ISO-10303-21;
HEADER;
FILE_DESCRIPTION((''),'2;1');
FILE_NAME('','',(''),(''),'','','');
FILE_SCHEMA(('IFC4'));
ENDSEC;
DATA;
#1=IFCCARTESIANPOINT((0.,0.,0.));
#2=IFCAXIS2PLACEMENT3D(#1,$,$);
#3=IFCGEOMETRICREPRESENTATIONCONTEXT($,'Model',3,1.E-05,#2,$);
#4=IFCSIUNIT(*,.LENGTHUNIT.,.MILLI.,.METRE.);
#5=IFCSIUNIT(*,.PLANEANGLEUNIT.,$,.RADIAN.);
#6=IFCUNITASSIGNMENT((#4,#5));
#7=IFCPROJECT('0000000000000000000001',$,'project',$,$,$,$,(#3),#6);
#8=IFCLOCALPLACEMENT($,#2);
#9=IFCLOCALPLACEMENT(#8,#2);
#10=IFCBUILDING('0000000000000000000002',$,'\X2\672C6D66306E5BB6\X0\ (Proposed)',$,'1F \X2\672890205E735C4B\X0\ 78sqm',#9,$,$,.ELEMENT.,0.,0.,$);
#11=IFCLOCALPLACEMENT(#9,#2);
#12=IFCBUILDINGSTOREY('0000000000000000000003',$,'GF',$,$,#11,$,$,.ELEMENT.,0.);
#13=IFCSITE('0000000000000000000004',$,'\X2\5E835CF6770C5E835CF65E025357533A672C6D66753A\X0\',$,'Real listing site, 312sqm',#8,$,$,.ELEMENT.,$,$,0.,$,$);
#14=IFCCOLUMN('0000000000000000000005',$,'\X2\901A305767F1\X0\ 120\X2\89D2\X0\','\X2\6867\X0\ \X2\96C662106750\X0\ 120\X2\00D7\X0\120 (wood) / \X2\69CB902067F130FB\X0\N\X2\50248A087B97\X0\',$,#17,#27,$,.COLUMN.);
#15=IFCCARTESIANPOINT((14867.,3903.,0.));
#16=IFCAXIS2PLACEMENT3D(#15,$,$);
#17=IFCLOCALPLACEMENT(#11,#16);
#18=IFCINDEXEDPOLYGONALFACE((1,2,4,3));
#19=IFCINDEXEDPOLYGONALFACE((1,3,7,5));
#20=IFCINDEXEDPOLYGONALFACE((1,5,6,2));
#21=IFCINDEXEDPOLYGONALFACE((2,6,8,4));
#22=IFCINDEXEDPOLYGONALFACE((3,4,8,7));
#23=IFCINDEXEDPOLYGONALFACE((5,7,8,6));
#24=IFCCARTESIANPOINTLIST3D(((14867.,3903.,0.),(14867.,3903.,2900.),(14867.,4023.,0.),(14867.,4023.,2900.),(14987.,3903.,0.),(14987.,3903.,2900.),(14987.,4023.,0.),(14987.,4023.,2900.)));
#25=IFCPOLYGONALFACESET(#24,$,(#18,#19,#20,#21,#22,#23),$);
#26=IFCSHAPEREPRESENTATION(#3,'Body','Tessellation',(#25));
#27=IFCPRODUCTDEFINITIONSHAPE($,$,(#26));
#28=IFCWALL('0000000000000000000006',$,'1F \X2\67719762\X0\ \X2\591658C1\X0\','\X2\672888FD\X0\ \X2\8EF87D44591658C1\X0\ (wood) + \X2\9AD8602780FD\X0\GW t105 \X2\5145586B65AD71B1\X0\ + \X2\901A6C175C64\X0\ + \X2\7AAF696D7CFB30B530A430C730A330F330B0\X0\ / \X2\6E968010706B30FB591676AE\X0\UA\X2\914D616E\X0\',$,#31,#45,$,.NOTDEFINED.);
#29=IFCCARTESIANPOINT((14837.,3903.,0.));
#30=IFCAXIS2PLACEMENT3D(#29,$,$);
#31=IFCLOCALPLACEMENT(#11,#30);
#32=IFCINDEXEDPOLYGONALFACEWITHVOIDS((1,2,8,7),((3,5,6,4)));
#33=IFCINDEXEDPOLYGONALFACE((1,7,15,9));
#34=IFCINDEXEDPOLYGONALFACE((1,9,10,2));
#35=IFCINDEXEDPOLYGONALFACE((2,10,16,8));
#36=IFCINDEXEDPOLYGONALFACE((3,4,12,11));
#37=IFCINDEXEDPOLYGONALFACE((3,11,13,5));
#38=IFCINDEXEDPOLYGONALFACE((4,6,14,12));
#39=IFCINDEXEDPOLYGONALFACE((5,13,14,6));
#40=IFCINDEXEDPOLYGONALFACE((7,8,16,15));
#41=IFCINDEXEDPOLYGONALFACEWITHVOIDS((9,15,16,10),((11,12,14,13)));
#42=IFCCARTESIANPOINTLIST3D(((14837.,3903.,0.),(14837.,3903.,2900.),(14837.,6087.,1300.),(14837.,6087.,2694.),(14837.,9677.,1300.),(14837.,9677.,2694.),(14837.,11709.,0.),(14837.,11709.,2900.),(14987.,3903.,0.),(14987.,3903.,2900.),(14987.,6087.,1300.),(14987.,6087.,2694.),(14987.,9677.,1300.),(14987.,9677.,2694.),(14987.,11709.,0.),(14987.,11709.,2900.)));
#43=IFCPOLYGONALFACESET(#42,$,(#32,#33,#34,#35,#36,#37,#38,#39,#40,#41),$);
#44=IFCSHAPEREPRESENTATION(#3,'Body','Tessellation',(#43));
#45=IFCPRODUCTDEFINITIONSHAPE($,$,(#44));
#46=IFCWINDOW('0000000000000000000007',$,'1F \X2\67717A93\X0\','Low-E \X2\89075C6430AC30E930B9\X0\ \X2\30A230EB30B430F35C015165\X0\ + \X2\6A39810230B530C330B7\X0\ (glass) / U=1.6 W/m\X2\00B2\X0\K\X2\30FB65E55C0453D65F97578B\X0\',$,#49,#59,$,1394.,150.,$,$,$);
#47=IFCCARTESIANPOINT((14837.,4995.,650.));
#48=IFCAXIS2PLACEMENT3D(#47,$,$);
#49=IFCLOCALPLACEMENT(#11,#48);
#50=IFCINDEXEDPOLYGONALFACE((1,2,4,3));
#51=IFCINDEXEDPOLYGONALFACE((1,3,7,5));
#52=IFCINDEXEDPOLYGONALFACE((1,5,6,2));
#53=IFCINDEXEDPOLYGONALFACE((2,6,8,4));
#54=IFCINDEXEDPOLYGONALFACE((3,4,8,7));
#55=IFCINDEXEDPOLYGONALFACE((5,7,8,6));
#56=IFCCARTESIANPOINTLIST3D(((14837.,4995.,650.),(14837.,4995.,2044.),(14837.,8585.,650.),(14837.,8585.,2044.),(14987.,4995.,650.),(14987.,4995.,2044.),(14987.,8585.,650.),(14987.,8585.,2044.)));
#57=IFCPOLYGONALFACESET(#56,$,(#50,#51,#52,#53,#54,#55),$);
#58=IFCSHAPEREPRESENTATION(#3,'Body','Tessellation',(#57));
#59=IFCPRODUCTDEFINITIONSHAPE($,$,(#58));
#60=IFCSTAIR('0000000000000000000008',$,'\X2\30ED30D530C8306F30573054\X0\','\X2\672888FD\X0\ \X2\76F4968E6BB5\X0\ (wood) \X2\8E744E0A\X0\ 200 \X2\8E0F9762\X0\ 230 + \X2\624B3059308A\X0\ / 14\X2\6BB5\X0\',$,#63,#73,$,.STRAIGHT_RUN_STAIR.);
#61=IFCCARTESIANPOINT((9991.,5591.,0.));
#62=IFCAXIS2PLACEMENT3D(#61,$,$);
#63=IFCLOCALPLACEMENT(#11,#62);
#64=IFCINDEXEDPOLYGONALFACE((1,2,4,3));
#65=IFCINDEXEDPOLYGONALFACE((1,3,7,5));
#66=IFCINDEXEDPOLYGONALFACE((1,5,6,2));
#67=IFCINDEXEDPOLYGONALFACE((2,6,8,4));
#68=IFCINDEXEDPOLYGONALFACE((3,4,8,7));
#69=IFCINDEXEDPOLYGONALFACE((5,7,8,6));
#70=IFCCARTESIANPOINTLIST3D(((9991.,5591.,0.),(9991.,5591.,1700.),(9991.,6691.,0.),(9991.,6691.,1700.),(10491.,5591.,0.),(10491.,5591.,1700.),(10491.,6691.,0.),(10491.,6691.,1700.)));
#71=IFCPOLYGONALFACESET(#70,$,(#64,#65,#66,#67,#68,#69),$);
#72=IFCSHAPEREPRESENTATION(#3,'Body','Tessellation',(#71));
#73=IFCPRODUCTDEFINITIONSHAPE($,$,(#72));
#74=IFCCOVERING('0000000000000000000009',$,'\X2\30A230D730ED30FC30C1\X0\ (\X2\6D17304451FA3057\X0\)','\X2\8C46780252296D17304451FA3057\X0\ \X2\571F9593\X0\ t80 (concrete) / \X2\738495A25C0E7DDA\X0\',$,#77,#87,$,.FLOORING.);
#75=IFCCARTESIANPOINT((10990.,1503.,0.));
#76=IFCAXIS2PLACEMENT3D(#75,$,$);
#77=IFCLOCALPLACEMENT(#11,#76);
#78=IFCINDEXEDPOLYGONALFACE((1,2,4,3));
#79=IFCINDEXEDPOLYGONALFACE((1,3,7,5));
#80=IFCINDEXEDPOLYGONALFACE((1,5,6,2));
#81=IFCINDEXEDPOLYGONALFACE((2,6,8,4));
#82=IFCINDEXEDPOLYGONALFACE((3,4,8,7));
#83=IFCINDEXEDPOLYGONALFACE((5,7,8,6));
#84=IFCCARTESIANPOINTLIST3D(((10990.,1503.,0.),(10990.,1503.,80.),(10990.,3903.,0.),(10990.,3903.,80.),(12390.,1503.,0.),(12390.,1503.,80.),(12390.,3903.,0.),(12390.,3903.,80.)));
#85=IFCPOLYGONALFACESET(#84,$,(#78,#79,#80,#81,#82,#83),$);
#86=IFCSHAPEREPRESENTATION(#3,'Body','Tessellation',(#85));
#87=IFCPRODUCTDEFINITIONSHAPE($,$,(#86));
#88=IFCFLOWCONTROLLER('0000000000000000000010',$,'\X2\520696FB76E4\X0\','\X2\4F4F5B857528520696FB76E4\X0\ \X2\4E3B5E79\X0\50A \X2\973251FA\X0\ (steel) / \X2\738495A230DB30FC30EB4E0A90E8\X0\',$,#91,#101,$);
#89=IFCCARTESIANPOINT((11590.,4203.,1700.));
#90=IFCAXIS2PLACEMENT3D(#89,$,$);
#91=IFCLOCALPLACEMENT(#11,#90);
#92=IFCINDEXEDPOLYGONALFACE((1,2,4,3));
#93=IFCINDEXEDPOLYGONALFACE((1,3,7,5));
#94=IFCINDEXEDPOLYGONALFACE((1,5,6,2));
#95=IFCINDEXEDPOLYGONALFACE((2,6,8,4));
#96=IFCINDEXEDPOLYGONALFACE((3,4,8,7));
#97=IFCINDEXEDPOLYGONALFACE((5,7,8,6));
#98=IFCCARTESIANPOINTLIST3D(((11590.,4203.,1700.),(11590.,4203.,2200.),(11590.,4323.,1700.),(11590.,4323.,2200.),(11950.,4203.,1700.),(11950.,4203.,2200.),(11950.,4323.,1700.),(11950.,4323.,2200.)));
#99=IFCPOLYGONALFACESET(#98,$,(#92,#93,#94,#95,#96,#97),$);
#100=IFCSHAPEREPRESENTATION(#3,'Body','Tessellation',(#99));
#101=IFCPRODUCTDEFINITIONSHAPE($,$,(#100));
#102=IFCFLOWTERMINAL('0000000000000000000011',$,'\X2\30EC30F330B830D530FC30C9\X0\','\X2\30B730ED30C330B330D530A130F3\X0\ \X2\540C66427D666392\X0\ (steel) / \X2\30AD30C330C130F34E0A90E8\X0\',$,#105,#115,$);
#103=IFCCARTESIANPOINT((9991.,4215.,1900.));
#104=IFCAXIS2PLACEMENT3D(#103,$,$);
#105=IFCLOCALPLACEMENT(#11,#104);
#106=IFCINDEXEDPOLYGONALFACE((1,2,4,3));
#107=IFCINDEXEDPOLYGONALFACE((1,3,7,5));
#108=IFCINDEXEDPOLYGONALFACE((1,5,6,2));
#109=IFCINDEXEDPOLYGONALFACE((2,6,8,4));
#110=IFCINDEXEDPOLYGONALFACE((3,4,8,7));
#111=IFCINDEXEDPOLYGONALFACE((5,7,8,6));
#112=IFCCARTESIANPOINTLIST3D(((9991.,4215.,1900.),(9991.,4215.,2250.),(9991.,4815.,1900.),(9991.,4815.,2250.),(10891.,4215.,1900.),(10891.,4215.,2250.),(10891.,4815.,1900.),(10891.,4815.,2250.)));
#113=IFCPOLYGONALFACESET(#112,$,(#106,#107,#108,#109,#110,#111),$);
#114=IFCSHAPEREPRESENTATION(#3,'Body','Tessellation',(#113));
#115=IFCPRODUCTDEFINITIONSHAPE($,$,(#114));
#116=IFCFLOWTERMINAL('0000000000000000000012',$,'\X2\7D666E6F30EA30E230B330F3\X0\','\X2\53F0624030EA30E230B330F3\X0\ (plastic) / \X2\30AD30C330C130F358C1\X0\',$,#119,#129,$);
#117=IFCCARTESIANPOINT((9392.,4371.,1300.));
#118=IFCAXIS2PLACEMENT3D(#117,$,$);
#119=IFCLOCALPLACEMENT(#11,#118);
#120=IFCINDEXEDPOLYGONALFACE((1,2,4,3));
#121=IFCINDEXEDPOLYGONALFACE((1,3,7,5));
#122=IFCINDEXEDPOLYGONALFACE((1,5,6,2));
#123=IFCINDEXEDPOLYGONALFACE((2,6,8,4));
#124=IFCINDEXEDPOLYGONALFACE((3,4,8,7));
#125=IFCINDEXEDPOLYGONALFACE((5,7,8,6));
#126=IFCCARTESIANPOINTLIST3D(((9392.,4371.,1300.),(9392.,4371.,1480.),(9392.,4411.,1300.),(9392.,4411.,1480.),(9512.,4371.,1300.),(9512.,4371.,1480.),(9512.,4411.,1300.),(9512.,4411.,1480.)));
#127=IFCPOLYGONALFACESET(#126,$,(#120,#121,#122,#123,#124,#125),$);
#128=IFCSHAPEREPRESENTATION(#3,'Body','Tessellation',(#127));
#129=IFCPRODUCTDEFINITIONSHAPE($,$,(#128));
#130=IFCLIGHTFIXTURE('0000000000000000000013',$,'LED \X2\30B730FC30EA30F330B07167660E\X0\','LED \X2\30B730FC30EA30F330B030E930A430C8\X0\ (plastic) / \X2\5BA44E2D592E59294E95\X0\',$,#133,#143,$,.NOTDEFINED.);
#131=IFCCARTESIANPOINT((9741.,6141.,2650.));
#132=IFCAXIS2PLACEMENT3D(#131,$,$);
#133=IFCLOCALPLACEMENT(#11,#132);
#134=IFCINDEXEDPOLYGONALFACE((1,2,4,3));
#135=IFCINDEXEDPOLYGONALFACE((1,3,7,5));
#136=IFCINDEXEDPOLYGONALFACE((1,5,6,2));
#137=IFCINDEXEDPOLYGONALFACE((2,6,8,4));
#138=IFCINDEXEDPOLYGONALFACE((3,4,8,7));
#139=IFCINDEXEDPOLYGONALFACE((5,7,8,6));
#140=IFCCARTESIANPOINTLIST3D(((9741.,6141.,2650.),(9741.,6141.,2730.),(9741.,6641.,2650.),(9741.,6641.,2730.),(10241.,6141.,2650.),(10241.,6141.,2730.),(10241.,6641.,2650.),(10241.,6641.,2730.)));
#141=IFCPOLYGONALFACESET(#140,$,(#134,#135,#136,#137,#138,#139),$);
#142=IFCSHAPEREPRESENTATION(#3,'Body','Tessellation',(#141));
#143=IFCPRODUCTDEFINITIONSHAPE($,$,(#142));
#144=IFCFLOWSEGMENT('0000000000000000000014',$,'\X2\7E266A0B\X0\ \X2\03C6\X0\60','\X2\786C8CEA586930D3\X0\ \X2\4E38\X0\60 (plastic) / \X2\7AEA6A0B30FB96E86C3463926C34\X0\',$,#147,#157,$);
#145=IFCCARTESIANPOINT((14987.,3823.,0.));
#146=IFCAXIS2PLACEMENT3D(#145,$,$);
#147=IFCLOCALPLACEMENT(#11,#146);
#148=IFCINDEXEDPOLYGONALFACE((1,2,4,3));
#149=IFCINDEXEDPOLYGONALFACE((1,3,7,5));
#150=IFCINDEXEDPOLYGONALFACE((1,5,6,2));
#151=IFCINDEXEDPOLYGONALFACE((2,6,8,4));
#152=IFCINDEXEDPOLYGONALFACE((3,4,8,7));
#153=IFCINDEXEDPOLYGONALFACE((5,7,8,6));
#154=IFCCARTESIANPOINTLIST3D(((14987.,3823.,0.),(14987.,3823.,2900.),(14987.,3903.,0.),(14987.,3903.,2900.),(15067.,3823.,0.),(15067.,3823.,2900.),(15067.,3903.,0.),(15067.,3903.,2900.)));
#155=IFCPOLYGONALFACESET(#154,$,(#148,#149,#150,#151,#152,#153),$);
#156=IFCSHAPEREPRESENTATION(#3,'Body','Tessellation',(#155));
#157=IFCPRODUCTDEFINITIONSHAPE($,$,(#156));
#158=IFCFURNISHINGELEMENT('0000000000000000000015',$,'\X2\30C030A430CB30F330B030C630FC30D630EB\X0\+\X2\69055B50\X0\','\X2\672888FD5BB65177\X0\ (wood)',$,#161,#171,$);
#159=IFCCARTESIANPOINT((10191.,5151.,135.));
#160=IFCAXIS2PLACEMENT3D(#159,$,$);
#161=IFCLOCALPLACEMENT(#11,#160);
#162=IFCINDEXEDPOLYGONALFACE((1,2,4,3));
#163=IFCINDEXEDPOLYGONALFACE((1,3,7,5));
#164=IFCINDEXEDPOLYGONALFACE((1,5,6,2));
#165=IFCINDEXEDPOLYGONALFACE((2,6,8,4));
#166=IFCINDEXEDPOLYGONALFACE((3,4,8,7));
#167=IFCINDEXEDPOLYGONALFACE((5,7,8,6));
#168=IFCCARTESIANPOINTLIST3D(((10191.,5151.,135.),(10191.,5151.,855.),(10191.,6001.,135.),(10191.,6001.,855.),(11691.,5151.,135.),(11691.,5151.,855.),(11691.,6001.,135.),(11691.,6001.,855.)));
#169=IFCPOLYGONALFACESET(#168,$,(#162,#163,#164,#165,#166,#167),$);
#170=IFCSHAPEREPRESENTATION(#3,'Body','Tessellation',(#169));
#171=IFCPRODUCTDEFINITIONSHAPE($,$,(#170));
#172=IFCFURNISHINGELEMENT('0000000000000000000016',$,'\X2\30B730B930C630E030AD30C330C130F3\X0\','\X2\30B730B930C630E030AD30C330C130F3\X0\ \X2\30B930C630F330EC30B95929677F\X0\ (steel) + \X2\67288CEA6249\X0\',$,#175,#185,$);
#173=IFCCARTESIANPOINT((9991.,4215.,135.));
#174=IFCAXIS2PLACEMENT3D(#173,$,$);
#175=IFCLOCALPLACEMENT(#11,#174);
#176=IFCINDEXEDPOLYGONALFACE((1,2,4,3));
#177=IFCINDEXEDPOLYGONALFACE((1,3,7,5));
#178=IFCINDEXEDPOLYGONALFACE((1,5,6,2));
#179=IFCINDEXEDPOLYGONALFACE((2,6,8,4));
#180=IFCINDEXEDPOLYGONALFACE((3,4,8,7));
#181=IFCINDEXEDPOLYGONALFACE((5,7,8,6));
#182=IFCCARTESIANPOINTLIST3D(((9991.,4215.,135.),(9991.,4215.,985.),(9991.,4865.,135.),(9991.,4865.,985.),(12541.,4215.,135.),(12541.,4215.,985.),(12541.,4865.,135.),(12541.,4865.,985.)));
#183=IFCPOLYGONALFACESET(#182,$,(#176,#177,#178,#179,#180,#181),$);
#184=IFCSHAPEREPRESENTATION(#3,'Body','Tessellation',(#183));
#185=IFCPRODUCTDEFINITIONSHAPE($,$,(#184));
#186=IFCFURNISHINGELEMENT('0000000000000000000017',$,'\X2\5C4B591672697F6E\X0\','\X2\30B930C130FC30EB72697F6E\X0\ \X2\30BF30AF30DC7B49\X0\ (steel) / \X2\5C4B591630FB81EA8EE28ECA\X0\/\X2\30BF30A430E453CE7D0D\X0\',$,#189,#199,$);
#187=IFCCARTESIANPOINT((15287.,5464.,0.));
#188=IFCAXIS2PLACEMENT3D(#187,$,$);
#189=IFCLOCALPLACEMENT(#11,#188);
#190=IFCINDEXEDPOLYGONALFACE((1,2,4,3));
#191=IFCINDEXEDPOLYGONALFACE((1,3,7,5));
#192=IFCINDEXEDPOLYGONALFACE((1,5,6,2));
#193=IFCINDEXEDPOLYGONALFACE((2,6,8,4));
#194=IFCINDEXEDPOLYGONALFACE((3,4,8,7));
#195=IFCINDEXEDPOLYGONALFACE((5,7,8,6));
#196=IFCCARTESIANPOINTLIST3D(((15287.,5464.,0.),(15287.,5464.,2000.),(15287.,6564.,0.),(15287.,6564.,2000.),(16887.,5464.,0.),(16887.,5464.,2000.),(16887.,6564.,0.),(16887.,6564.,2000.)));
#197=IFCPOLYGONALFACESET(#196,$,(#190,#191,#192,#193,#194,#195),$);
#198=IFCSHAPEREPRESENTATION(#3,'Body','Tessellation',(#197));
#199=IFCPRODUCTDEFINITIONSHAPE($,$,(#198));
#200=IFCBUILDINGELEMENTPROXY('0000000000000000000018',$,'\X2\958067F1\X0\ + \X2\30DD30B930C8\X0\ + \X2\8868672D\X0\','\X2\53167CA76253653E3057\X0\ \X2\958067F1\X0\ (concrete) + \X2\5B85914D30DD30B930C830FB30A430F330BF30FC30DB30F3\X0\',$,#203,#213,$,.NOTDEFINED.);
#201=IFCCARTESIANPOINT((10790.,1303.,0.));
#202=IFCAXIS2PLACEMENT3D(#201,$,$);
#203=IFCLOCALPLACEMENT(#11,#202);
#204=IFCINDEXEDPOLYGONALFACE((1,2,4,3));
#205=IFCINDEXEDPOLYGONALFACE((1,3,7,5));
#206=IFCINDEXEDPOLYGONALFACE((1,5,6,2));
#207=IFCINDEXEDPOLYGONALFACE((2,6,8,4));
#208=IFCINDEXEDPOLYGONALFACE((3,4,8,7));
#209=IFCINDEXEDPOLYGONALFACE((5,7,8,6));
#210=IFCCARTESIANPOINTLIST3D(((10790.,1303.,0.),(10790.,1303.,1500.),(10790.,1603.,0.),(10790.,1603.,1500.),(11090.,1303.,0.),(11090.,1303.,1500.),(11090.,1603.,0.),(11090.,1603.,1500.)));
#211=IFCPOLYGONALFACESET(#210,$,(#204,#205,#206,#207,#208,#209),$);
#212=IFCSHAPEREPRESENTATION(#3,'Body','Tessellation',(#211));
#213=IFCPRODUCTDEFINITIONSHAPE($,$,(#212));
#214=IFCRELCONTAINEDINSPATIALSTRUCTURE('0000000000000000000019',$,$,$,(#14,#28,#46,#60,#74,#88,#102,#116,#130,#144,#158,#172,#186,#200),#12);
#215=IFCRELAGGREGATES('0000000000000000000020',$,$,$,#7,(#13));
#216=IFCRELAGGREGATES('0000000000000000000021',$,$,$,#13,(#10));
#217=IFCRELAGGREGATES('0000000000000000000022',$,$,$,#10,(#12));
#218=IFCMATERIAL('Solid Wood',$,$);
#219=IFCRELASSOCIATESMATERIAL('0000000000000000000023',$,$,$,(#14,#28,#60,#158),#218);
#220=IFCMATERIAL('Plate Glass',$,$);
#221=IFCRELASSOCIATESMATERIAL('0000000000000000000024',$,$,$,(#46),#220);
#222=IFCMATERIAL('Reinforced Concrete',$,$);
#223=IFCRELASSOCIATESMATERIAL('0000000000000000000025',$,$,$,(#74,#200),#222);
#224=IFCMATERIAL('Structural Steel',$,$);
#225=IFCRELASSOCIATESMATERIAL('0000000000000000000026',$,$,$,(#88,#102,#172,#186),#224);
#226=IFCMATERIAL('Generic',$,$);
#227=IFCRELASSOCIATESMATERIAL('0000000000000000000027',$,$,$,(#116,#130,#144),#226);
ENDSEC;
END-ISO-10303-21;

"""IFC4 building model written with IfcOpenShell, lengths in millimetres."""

from ifc_helpers import new_model, si_unit, frame, frame_2d, origin, place, context, project, spatial, rectangle, extrude, material, element, fill, save


model = new_model("IFC4")

# Units and contexts
model_context = context("Model", 3, precision=1e-05, world=origin())
ifc_project = project(units=[si_unit("LENGTHUNIT", "METRE", prefix="MILLI"), si_unit("PLANEANGLEUNIT", "RADIAN")], contexts=[model_context])

# Site, building, storey
site_placement = place(None, origin())
site = spatial("IfcSite", under=ifc_project, at=site_placement, Name="広島県広島市南区本浦町", ObjectType="Real listing site, 312sqm", CompositionType="ELEMENT", RefElevation=0.0)
building_placement = place(site_placement, origin())
building = spatial("IfcBuilding", under=site, at=building_placement, Name="本浦の家 (Proposed)", ObjectType="1F 木造平屋 78sqm", CompositionType="ELEMENT", ElevationOfRefHeight=0.0, ElevationOfTerrain=0.0)
storey_placement = place(building_placement, origin())
storey = spatial("IfcBuildingStorey", under=building, at=storey_placement, Name="GF", CompositionType="ELEMENT", Elevation=0.0)

# Column
ifc_material_1 = material(Name="Solid Wood")
column_1_placement = place(storey_placement, frame((14867.0, 3903.0, 0.0)))
element("IfcColumn", 1, at=column_1_placement, inside=storey, material=ifc_material_1, Name="通し柱 120角", Description="桧 集成材 120×120 (wood) / 構造柱・N値計算", PredefinedType="COLUMN", context=model_context, shape_type="SweptSolid", body=[
    extrude(rectangle(XDim=120.0, YDim=120.0, at=frame_2d((60.0, 60.0))), frame((14867.0, 3903.0, 0.0)), (0.0, 0.0, 1.0), 2900.0),
])

# Wall, opening, window
wall_1_placement = place(storey_placement, frame((14837.0, 3903.0, 0.0)))
wall_1 = element("IfcWall", 2, at=wall_1_placement, inside=storey, material=ifc_material_1, Name="1F 東面 外壁", Description="木製 軸組外壁 (wood) + 高性能GW t105 充填断熱 + 通気層 + 窯業系サイディング / 準耐火・外皮UA配慮", PredefinedType="NOTDEFINED", context=model_context, shape_type="SweptSolid", body=[
    extrude(rectangle(XDim=150.0, YDim=7806.0, at=frame_2d((75.0, 3903.0))), frame((14837.0, 3903.0, 0.0)), (0.0, 0.0, 1.0), 2900.0),
])
opening_placement = place(storey_placement, frame((14837.0, 4995.0, 650.0)))
opening = element("IfcOpeningElement", 3, at=opening_placement, cuts=wall_1, PredefinedType="NOTDEFINED", context=model_context, shape_type="SweptSolid", body=[
    extrude(rectangle(XDim=150.0, YDim=3590.0, at=frame_2d((75.0, 1795.0))), frame((14837.0, 4995.0, 650.0)), (0.0, 0.0, 1.0), 1394.0),
])
ifc_material_2 = material(Name="Plate Glass")
window_placement = place(storey_placement, frame((14837.0, 4995.0, 650.0)))
window = element("IfcWindow", 4, at=window_placement, inside=storey, material=ifc_material_2, Name="1F 東窓", Description="Low-E 複層ガラス アルゴン封入 + 樹脂サッシ (glass) / U=1.6 W/m²K・日射取得型", OverallHeight=1394.0, OverallWidth=150.0, context=model_context, shape_type="SweptSolid", body=[
    extrude(rectangle(XDim=150.0, YDim=3590.0, at=frame_2d((75.0, 1795.0))), frame((14837.0, 4995.0, 650.0)), (0.0, 0.0, 1.0), 1394.0),
])
fill(opening, window)

# Stair
stair_placement = place(storey_placement, frame((9991.0, 5591.0, 0.0)))
element("IfcStair", 5, at=stair_placement, inside=storey, material=ifc_material_1, Name="ロフトはしご", Description="木製 直階段 (wood) 蹴上 200 踏面 230 + 手すり / 14段", PredefinedType="STRAIGHT_RUN_STAIR", context=model_context, shape_type="SweptSolid", body=[
    extrude(rectangle(XDim=500.0, YDim=1100.0, at=frame_2d((250.0, 550.0))), frame((9991.0, 5591.0, 0.0)), (0.0, 0.0, 1.0), 1700.0),
])

# Covering
ifc_material_3 = material(Name="Reinforced Concrete")
covering_placement = place(storey_placement, frame((10990.0, 1503.0, 0.0)))
element("IfcCovering", 6, at=covering_placement, inside=storey, material=ifc_material_3, Name="アプローチ (洗い出し)", Description="豆砂利洗い出し 土間 t80 (concrete) / 玄関導線", PredefinedType="FLOORING", context=model_context, shape_type="SweptSolid", body=[
    extrude(rectangle(XDim=1400.0, YDim=2400.0, at=frame_2d((700.0, 1200.0))), frame((10990.0, 1503.0, 0.0)), (0.0, 0.0, 1.0), 80.0),
])

# Flow controller
ifc_material_4 = material(Name="Structural Steel")
flow_controller_placement = place(storey_placement, frame((11590.0, 4203.0, 1700.0)))
element("IfcFlowController", 7, at=flow_controller_placement, inside=storey, material=ifc_material_4, Name="分電盤", Description="住宅用分電盤 主幹50A 露出 (steel) / 玄関ホール上部", context=model_context, shape_type="SweptSolid", body=[
    extrude(rectangle(XDim=360.0, YDim=120.0, at=frame_2d((180.0, 60.0))), frame((11590.0, 4203.0, 1700.0)), (0.0, 0.0, 1.0), 500.0),
])

# Flow terminals
flow_terminal_1_placement = place(storey_placement, frame((9991.0, 4215.0, 1900.0)))
element("IfcFlowTerminal", 8, at=flow_terminal_1_placement, inside=storey, material=ifc_material_4, Name="レンジフード", Description="シロッコファン 同時給排 (steel) / キッチン上部", context=model_context, shape_type="SweptSolid", body=[
    extrude(rectangle(XDim=900.0, YDim=600.0, at=frame_2d((450.0, 300.0))), frame((9991.0, 4215.0, 1900.0)), (0.0, 0.0, 1.0), 350.0),
])
ifc_material_5 = material(Name="Generic")
flow_terminal_2_placement = place(storey_placement, frame((9392.0, 4371.0, 1300.0)))
element("IfcFlowTerminal", 9, at=flow_terminal_2_placement, inside=storey, material=ifc_material_5, Name="給湯リモコン", Description="台所リモコン (plastic) / キッチン壁", context=model_context, shape_type="SweptSolid", body=[
    extrude(rectangle(XDim=120.0, YDim=40.0, at=frame_2d((60.0, 20.0))), frame((9392.0, 4371.0, 1300.0)), (0.0, 0.0, 1.0), 180.0),
])

# Light fixture
light_fixture_placement = place(storey_placement, frame((9741.0, 6141.0, 2650.0)))
element("IfcLightFixture", 10, at=light_fixture_placement, inside=storey, material=ifc_material_5, Name="LED シーリング照明", Description="LED シーリングライト (plastic) / 室中央天井", PredefinedType="NOTDEFINED", context=model_context, shape_type="SweptSolid", body=[
    extrude(rectangle(XDim=500.0, YDim=500.0, at=frame_2d((250.0, 250.0))), frame((9741.0, 6141.0, 2650.0)), (0.0, 0.0, 1.0), 80.0),
])

# Flow segment
flow_segment_placement = place(storey_placement, frame((14987.0, 3823.0, 0.0)))
element("IfcFlowSegment", 11, at=flow_segment_placement, inside=storey, material=ifc_material_5, Name="縦樋 φ60", Description="硬質塩ビ 丸60 (plastic) / 竪樋・雨水排水", context=model_context, shape_type="SweptSolid", body=[
    extrude(rectangle(XDim=80.0, YDim=80.0, at=frame_2d((40.0, 40.0))), frame((14987.0, 3823.0, 0.0)), (0.0, 0.0, 1.0), 2900.0),
])

# Furnishing elements
furnishing_1_placement = place(storey_placement, frame((10191.0, 5151.0, 135.0)))
element("IfcFurnishingElement", 12, at=furnishing_1_placement, inside=storey, material=ifc_material_1, Name="ダイニングテーブル+椅子", Description="木製家具 (wood)", context=model_context, shape_type="SweptSolid", body=[
    extrude(rectangle(XDim=1500.0, YDim=850.0, at=frame_2d((750.0, 425.0))), frame((10191.0, 5151.0, 135.0)), (0.0, 0.0, 1.0), 720.0),
])
furnishing_2_placement = place(storey_placement, frame((9991.0, 4215.0, 135.0)))
element("IfcFurnishingElement", 13, at=furnishing_2_placement, inside=storey, material=ifc_material_4, Name="システムキッチン", Description="システムキッチン ステンレス天板 (steel) + 木質扉", context=model_context, shape_type="SweptSolid", body=[
    extrude(rectangle(XDim=2550.0, YDim=650.0, at=frame_2d((1275.0, 325.0))), frame((9991.0, 4215.0, 135.0)), (0.0, 0.0, 1.0), 850.0),
])
furnishing_3_placement = place(storey_placement, frame((15287.0, 5464.0, 0.0)))
element("IfcFurnishingElement", 14, at=furnishing_3_placement, inside=storey, material=ifc_material_4, Name="屋外物置", Description="スチール物置 タクボ等 (steel) / 屋外・自転車/タイヤ収納", context=model_context, shape_type="SweptSolid", body=[
    extrude(rectangle(XDim=1600.0, YDim=1100.0, at=frame_2d((800.0, 550.0))), frame((15287.0, 5464.0, 0.0)), (0.0, 0.0, 1.0), 2000.0),
])

# Building element proxy
proxy_placement = place(storey_placement, frame((10790.0, 1303.0, 0.0)))
element("IfcBuildingElementProxy", 15, at=proxy_placement, inside=storey, material=ifc_material_3, Name="門柱 + ポスト + 表札", Description="化粧打放し 門柱 (concrete) + 宅配ポスト・インターホン", PredefinedType="NOTDEFINED", context=model_context, shape_type="SweptSolid", body=[
    extrude(rectangle(XDim=300.0, YDim=300.0, at=frame_2d((150.0, 150.0))), frame((10790.0, 1303.0, 0.0)), (0.0, 0.0, 1.0), 1500.0),
])

save(model, "model.ifc")
